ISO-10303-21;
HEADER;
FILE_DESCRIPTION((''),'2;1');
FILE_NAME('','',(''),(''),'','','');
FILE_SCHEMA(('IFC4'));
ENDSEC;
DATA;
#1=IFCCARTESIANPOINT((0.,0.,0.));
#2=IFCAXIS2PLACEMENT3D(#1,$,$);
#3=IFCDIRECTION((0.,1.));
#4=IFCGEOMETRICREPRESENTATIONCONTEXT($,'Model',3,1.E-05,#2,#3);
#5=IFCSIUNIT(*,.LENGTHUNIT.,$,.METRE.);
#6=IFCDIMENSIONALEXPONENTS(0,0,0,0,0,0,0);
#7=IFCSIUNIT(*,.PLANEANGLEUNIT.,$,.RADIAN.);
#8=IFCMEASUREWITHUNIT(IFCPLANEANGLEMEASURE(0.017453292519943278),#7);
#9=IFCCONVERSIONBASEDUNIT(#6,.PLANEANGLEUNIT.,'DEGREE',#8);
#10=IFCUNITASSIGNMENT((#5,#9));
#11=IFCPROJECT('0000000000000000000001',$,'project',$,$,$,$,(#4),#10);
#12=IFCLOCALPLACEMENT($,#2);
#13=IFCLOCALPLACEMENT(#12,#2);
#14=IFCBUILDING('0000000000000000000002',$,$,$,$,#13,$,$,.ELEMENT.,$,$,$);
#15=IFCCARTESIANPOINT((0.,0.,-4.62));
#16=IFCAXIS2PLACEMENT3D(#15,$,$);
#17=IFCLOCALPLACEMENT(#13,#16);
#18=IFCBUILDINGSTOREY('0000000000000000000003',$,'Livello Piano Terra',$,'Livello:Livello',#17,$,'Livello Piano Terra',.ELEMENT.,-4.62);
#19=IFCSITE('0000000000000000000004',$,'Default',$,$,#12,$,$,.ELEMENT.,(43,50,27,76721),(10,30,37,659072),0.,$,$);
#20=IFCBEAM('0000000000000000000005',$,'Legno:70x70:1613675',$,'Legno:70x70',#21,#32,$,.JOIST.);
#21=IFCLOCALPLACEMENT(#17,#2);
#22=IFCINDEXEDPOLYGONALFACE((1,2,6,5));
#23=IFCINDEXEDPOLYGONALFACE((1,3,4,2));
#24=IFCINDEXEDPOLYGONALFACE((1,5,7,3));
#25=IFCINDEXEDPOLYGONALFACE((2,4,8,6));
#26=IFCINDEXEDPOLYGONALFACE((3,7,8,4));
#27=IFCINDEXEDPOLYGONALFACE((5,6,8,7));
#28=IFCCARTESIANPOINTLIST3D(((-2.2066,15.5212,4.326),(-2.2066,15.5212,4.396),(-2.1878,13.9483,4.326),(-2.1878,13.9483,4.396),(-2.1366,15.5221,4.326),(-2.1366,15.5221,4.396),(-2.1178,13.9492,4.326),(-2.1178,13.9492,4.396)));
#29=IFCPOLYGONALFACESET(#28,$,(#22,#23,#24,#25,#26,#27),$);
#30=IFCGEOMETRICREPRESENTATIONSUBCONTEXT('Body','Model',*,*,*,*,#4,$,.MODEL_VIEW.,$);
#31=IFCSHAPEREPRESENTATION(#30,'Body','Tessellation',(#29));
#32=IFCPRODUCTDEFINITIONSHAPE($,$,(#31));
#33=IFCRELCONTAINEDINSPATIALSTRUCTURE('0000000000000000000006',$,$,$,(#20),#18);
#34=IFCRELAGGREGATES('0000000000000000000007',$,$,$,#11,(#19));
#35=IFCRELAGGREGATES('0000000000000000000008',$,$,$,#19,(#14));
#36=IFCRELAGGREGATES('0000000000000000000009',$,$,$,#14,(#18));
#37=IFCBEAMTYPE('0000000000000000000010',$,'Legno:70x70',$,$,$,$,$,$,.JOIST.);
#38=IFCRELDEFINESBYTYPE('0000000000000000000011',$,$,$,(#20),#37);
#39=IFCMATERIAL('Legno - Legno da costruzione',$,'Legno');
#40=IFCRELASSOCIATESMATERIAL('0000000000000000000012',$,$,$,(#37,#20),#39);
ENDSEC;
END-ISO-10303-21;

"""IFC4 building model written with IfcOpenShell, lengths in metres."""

from ifc_helpers import new_model, entity, si_unit, converted_unit, direction, frame, origin, place, context, subcontext, project, spatial, indexed_curve, outline, extrude, source, transform, mapped, material, type_object, type_shapes, element, save


model = new_model("IFC4")

# Units and contexts
model_context = context("Model", 3, precision=1e-05, world=origin(), true_north=direction((0.0, 1.0)))
body_context = subcontext(model_context, "Body", "Model", "MODEL_VIEW")
ifc_project = project(units=[si_unit("LENGTHUNIT", "METRE"), converted_unit("PLANEANGLEUNIT", "DEGREE", entity("IfcPlaneAngleMeasure", 0.017453292519943278), si_unit("PLANEANGLEUNIT", "RADIAN"), dimensions=[0, 0, 0, 0, 0, 0, 0])], contexts=[model_context])

# Site, building, storey
site_placement = place(None, origin())
site = spatial("IfcSite", under=ifc_project, at=site_placement, Name="Default", CompositionType="ELEMENT", RefLatitude=(43, 50, 27, 76721), RefLongitude=(10, 30, 37, 659072), RefElevation=0.0)
building_placement = place(site_placement, origin())
building = spatial("IfcBuilding", under=site, at=building_placement, CompositionType="ELEMENT")
storey_placement = place(building_placement, frame((0.0, 0.0, -4.62)))
storey = spatial("IfcBuildingStorey", under=building, at=storey_placement, Name="Livello Piano Terra", ObjectType="Livello:Livello", LongName="Livello Piano Terra", CompositionType="ELEMENT", Elevation=-4.62)

# Beam
ifc_material = material(Name="Legno - Legno da costruzione", Category="Legno")
beam_type_1 = type_object("IfcBeamType", Name="Legno:70x70", PredefinedType="JOIST", material=ifc_material)
shared_shape_1 = source(origin(), body_context, "Body", "SweptSolid", [
    extrude(outline(indexed_curve([(-0.7865, -0.035), (0.7865, -0.035), (0.7865, 0.035), (-0.7865, 0.035), (-0.7865, -0.035)], self_intersect=False)), frame((0.0, 0.0, -0.035), z_axis=(0.0, 0.0, 1.0), x_axis=(-1.0, 0.0, 0.0)), (0.0, 0.0, 1.0), 0.07),
])
type_shapes(beam_type_1, [shared_shape_1])
for number, where, z_axis, x_axis, name in (
    (1, (-2.1622, 14.7352, 4.361), (0.0, 0.0, 1.0), (0.011914, -0.999929, 0.0), "Legno:70x70:1613675"),
):
    element("IfcBeam", number, at=place(storey_placement, frame(where, z_axis=z_axis, x_axis=x_axis)), inside=storey, type_object=beam_type_1, material=ifc_material, Name=name, ObjectType="Legno:70x70", PredefinedType="JOIST", context=body_context, shape_type="MappedRepresentation", body=[
        mapped(shared_shape_1, transform((0.0, 0.0, 0.0), scale=1.0)),
    ])

save(model, "model.ifc")
